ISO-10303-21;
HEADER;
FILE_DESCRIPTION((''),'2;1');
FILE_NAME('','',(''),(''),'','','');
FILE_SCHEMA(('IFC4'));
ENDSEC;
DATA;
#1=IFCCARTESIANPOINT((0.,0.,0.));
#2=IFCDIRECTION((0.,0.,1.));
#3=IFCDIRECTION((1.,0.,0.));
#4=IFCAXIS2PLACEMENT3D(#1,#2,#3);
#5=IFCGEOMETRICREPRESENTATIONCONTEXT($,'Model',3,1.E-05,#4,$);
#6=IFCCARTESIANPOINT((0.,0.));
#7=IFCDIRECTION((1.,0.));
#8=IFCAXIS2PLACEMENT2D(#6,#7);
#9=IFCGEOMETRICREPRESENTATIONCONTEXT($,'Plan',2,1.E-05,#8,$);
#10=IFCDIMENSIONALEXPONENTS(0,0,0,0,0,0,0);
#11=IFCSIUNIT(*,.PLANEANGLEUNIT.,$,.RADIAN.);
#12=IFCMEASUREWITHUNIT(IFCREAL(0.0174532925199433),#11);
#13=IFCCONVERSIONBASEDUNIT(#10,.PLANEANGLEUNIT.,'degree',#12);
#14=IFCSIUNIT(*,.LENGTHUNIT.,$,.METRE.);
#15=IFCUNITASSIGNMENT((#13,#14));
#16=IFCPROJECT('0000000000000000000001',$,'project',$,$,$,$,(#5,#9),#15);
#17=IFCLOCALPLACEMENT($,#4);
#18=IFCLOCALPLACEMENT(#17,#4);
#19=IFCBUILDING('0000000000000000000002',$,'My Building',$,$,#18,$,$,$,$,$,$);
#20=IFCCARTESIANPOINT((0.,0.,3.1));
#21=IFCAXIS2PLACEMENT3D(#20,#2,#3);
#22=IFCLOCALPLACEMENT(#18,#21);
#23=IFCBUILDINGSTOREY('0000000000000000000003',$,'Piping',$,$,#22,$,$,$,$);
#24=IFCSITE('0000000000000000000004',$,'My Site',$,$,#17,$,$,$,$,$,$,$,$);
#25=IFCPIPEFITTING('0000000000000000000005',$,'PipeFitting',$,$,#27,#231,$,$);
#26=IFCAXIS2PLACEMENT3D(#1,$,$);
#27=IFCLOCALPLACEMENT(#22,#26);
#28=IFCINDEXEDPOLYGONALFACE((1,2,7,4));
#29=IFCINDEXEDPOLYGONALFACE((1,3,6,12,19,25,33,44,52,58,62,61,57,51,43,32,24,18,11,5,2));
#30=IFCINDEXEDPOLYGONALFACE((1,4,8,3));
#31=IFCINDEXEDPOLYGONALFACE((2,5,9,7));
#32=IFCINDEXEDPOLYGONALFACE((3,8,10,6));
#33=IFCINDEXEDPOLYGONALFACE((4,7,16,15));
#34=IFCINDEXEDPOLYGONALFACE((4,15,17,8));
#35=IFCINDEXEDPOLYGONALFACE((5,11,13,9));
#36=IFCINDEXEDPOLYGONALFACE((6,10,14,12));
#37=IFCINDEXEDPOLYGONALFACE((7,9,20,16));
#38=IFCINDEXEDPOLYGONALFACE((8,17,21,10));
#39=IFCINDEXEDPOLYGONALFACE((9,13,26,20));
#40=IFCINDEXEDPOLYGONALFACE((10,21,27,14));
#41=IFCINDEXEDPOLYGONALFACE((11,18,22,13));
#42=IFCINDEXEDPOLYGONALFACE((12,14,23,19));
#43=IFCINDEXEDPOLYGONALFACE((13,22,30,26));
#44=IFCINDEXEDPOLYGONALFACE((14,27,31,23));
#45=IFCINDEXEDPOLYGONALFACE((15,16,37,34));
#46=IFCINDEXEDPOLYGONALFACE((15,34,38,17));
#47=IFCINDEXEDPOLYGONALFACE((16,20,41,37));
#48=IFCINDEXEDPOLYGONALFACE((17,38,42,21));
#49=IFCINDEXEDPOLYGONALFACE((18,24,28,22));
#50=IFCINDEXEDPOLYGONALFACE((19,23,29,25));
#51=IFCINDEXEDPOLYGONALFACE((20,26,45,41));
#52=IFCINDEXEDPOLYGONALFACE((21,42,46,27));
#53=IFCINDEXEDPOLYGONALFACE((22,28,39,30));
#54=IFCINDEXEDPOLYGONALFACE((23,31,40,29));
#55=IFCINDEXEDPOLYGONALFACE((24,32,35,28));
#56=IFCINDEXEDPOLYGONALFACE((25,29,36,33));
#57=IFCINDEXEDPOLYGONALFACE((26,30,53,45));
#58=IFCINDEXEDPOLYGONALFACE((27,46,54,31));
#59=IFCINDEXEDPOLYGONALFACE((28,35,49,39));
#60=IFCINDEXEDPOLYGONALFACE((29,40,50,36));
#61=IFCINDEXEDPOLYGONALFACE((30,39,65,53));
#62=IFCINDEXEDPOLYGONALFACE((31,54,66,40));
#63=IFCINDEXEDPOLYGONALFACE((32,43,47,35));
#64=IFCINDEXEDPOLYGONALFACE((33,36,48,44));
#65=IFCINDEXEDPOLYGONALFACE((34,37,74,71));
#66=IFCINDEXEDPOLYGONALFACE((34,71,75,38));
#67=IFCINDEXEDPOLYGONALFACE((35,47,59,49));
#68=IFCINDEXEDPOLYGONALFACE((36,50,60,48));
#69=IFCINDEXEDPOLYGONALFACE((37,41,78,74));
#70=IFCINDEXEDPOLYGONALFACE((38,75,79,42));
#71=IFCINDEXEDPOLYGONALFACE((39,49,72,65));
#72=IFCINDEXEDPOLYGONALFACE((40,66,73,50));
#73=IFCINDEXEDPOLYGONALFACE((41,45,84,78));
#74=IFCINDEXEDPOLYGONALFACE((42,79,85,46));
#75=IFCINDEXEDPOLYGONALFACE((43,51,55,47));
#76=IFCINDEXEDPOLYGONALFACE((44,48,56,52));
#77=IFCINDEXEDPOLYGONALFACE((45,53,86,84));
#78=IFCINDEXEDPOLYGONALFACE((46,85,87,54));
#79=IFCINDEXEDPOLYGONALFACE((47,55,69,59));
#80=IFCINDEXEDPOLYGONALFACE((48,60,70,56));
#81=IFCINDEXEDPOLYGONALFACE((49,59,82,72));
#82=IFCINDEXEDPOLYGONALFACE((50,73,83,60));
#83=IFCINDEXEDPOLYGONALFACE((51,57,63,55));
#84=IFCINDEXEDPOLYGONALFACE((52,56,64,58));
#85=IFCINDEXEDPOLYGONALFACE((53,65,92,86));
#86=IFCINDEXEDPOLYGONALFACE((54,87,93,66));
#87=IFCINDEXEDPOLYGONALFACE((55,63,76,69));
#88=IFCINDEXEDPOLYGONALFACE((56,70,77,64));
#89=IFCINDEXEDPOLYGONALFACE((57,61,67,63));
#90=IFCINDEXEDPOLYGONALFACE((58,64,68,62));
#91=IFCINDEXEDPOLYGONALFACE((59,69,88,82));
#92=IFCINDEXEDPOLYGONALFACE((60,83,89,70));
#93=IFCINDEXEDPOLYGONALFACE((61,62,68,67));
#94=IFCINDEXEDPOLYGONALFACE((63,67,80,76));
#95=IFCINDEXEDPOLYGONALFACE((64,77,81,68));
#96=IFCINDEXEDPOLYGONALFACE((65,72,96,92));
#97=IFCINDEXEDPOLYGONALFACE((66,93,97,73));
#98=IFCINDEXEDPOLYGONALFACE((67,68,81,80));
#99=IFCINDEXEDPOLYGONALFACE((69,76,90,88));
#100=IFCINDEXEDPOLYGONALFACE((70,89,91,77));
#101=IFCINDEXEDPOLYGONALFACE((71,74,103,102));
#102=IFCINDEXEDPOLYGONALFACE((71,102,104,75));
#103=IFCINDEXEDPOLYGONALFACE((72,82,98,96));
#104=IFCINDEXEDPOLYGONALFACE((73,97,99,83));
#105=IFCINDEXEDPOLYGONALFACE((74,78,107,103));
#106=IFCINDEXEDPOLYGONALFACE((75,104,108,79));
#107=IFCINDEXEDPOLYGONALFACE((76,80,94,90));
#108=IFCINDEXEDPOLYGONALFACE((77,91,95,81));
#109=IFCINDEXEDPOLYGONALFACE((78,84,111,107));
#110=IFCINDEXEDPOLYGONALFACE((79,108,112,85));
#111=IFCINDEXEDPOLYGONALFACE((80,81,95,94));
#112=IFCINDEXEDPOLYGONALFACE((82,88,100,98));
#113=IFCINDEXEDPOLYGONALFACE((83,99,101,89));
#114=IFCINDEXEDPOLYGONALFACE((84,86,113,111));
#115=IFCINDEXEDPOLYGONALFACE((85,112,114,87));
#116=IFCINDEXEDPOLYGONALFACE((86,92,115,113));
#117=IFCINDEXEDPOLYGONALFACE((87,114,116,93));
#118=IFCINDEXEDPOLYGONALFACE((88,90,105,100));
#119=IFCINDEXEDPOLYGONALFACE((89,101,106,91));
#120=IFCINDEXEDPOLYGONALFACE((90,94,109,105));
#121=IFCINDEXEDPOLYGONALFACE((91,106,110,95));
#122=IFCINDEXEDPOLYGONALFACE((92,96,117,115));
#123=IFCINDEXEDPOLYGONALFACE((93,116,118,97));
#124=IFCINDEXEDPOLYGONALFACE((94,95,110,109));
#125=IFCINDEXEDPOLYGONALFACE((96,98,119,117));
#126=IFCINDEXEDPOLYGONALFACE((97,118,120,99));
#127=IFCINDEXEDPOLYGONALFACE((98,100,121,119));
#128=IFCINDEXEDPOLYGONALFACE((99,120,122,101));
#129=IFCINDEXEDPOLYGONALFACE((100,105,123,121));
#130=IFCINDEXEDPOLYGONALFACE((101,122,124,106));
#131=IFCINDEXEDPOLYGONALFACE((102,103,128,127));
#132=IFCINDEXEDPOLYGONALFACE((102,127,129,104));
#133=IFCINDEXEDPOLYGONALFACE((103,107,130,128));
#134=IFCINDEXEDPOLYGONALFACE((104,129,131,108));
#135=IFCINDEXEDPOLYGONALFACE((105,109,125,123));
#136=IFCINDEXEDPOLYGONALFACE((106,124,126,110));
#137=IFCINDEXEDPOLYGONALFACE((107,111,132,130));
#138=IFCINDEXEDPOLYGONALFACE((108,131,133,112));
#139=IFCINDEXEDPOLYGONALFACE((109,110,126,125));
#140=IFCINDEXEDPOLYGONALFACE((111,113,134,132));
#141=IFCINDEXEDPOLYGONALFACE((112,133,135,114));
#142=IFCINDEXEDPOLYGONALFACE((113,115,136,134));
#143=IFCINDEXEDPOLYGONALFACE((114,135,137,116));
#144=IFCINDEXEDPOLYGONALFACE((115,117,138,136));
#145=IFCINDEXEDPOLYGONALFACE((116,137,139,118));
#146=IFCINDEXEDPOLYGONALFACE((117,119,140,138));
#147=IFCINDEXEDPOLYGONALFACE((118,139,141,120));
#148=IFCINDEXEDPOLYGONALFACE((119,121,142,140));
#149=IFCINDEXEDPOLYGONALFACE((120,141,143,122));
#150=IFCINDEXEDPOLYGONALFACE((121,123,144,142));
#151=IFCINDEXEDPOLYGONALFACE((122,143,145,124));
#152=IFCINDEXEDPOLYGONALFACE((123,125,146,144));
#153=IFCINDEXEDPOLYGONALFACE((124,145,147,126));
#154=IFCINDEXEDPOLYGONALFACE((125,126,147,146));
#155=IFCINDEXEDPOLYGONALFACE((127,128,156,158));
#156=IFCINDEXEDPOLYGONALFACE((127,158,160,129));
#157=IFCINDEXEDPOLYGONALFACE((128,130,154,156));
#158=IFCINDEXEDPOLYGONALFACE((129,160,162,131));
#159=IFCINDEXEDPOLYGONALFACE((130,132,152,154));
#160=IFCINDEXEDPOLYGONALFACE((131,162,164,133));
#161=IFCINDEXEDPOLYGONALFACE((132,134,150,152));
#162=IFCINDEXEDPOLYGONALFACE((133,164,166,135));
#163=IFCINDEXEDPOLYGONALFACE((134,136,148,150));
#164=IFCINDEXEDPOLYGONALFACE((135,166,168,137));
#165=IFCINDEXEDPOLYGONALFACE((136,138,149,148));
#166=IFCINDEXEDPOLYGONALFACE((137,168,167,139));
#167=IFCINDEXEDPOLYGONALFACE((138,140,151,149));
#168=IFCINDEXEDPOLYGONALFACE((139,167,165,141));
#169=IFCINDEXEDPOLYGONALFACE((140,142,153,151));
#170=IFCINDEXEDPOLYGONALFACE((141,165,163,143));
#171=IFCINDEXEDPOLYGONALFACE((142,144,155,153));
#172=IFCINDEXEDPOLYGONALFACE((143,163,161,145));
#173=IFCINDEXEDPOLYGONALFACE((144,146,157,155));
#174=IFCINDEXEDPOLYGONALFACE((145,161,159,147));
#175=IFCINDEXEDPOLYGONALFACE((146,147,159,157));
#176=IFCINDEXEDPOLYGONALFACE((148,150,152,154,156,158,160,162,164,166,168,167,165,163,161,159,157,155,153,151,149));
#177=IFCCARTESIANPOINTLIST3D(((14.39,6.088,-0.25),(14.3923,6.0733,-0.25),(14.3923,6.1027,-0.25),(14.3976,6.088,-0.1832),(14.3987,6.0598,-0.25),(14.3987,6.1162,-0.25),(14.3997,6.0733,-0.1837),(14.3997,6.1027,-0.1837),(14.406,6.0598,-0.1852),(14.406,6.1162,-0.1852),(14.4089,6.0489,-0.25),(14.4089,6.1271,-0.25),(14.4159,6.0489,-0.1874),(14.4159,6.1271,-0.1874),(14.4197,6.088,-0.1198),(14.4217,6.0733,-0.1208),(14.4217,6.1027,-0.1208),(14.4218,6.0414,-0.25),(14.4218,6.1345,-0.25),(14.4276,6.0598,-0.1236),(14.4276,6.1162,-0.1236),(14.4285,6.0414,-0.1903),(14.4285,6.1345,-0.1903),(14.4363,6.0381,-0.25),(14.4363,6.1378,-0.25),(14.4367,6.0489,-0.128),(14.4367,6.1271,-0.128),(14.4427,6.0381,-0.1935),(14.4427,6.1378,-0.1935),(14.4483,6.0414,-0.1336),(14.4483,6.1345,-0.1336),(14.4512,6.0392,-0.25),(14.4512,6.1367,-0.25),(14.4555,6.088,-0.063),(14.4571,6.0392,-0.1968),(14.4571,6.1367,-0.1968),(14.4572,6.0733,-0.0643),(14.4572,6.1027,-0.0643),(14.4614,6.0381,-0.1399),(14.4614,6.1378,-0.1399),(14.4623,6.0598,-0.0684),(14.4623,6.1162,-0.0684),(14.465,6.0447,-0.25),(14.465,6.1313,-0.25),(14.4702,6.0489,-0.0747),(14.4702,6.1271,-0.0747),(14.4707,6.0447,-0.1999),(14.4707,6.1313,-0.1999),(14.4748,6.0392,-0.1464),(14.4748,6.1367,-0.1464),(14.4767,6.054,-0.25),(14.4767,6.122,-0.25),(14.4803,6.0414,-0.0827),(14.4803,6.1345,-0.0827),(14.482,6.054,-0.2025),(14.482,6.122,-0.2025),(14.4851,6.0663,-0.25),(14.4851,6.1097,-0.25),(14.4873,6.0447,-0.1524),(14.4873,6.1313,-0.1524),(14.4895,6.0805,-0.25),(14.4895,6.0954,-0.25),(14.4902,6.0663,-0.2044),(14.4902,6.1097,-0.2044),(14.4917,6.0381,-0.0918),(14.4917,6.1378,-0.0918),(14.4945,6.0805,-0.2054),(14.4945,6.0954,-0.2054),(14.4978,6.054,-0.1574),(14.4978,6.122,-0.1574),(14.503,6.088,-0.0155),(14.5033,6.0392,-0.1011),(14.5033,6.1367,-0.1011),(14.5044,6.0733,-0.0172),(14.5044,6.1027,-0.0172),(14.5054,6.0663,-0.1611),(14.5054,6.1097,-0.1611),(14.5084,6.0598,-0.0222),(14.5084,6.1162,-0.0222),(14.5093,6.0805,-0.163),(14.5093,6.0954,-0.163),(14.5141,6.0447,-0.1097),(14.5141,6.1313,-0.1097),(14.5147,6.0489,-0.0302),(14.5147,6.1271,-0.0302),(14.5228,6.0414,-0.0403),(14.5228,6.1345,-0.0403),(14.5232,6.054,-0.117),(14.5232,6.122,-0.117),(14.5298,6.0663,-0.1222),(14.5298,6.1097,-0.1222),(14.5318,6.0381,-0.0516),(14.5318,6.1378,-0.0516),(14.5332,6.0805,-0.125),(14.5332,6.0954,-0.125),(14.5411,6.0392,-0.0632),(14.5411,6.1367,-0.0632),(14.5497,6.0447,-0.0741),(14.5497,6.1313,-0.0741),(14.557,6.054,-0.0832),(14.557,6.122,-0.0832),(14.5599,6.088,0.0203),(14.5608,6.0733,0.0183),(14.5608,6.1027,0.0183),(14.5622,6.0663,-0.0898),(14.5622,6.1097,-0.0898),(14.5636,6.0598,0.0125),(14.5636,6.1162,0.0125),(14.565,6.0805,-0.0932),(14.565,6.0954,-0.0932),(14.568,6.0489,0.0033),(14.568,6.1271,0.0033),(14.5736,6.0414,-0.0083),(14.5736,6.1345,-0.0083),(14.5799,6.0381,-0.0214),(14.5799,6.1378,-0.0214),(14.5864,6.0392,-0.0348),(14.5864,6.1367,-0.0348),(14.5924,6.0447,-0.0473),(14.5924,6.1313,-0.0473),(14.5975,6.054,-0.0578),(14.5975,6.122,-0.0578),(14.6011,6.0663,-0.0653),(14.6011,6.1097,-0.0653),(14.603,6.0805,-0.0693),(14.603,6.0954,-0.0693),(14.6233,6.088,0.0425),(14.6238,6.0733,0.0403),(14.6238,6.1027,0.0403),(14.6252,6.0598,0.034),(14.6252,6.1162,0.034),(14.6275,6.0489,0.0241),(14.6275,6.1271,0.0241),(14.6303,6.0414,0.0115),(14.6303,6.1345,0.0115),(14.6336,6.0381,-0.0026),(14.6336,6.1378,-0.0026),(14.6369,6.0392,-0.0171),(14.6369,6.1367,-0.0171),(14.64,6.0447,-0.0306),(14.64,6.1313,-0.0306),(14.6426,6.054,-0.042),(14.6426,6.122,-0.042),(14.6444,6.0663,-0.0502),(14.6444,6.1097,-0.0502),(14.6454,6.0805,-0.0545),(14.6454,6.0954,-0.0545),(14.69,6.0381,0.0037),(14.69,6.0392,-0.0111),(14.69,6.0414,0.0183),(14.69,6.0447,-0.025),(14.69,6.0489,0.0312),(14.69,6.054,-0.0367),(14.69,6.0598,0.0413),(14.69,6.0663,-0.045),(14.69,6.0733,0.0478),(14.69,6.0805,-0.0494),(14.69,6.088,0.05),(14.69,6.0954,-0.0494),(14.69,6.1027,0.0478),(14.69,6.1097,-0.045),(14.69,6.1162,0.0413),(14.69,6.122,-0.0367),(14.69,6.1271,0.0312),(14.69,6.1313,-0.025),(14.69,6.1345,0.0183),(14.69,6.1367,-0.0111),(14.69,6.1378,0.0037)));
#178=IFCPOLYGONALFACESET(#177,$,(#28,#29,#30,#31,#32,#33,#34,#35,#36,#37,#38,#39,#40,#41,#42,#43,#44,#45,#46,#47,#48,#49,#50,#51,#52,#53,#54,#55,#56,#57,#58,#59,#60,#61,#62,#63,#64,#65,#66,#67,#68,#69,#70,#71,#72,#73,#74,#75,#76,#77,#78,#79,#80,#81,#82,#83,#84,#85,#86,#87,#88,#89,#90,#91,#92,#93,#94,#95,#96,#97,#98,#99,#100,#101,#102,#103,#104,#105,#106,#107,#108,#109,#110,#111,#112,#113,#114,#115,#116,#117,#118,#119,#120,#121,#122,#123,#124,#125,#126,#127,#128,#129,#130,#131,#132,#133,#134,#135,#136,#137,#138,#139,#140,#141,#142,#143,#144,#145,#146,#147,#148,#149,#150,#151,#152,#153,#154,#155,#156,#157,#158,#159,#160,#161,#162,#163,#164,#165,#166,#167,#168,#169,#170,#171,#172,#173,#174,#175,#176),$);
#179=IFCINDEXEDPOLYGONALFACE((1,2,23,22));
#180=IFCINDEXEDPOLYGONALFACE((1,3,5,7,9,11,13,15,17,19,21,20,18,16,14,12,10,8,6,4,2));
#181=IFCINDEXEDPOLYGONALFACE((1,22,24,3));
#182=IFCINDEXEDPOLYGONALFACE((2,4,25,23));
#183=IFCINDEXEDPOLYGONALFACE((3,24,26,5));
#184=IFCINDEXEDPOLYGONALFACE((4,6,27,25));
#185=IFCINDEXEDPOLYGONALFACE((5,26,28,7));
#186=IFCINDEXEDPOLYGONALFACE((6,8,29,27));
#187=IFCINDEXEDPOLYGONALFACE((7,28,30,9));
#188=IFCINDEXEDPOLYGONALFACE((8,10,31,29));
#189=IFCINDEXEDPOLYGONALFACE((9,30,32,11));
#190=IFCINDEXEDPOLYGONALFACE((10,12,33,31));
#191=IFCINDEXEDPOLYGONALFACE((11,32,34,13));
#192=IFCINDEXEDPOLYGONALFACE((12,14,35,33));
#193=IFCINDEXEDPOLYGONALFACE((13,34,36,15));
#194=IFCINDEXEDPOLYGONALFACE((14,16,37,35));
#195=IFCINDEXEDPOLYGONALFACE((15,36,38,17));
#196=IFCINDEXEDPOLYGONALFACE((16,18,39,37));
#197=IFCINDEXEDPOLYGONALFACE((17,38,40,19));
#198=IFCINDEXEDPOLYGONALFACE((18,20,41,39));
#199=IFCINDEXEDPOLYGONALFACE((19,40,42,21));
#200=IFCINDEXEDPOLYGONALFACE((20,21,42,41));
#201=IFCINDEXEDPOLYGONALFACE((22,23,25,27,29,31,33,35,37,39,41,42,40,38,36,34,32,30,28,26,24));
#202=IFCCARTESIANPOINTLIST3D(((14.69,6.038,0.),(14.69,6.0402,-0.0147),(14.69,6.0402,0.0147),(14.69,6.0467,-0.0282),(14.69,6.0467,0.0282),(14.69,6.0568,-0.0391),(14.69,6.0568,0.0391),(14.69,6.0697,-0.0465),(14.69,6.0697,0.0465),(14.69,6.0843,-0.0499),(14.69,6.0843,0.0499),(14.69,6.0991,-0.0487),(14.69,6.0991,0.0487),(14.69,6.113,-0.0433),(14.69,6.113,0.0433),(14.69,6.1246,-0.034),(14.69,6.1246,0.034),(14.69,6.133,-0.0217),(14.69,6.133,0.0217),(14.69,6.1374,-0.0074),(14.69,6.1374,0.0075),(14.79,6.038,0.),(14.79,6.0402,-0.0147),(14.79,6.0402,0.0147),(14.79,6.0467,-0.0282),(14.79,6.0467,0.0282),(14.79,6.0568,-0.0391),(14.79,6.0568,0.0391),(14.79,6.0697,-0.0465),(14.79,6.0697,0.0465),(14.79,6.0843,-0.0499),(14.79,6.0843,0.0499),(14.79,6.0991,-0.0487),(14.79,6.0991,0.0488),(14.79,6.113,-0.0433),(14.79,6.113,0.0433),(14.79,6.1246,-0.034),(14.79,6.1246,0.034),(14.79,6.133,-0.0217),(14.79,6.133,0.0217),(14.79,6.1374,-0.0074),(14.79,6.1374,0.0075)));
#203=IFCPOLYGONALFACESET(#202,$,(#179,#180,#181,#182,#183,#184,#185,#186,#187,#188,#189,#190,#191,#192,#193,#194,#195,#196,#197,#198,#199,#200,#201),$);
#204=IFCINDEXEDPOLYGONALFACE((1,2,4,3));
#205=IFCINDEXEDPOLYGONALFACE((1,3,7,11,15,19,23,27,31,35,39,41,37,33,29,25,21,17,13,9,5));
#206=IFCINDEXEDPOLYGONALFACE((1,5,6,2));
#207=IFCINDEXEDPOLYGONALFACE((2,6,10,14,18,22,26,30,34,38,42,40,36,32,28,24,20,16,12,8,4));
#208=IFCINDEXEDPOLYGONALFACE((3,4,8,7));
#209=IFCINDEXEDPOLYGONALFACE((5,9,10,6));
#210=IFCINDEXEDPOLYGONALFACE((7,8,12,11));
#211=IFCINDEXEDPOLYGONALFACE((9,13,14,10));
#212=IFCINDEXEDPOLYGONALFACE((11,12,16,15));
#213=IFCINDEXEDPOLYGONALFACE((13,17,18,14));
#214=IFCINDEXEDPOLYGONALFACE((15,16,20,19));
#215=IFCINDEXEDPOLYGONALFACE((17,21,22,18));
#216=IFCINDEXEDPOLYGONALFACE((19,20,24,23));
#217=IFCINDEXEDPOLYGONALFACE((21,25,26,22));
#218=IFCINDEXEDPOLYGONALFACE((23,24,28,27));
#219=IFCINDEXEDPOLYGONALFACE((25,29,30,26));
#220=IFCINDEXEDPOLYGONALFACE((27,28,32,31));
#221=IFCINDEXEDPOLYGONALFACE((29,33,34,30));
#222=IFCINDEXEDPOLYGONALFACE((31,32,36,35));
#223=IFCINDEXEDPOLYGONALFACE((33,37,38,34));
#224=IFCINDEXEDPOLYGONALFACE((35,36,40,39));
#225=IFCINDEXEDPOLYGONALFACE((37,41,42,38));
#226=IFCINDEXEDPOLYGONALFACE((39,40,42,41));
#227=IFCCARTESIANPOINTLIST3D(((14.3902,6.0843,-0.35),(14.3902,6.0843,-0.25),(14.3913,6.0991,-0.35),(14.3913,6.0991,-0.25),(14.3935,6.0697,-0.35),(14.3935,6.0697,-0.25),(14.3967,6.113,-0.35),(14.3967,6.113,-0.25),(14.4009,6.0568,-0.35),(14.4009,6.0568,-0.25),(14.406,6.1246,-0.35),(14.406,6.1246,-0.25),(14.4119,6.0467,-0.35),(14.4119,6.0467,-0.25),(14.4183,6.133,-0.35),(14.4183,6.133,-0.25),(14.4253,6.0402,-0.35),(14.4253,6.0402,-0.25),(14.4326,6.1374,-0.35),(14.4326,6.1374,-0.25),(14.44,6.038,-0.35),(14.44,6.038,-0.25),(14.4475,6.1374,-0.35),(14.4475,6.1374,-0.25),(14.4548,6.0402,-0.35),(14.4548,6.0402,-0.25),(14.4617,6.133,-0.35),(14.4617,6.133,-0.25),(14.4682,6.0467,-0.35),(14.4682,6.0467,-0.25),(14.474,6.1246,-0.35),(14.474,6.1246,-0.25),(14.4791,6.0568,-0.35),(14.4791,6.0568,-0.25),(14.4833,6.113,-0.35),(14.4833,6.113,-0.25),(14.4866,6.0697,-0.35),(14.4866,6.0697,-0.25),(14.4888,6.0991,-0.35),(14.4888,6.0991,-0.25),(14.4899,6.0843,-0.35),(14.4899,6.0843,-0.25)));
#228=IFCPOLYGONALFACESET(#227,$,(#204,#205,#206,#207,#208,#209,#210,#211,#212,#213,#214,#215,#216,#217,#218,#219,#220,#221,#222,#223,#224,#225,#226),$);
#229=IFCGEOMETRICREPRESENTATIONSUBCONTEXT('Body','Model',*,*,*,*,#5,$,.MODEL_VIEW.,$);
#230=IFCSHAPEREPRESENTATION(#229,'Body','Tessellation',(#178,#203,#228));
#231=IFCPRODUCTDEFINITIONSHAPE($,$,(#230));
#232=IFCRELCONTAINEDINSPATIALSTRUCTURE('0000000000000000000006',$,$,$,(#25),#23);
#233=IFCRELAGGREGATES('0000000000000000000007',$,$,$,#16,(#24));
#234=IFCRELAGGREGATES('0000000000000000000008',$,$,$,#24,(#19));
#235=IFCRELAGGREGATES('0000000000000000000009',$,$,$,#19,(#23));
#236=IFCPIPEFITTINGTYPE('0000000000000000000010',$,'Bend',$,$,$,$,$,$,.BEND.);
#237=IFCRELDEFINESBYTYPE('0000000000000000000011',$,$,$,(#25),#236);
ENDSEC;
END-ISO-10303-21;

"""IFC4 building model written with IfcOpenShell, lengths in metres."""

from ifc_helpers import new_model, entity, si_unit, converted_unit, frame, origin_with_axes, origin_2d_with_axis, place, context, subcontext, project, spatial, circle, extrude, source, transform, mapped, type_object, type_shapes, element, save


model = new_model("IFC4")

# Units and contexts
model_context = context("Model", 3, precision=1e-05, world=origin_with_axes())
plan_context = context("Plan", 2, precision=1e-05, world=origin_2d_with_axis())
body_context = subcontext(model_context, "Body", "Model", "MODEL_VIEW")
ifc_project = project(units=[converted_unit("PLANEANGLEUNIT", "degree", entity("IfcReal", 0.0174532925199433), si_unit("PLANEANGLEUNIT", "RADIAN"), dimensions=[0, 0, 0, 0, 0, 0, 0]), si_unit("LENGTHUNIT", "METRE")], contexts=[model_context, plan_context])

# Site, building, storey
site_placement = place(None, origin_with_axes())
site = spatial("IfcSite", under=ifc_project, at=site_placement, Name="My Site")
building_placement = place(site_placement, origin_with_axes())
building = spatial("IfcBuilding", under=site, at=building_placement, Name="My Building")
storey_placement = place(building_placement, frame((0.0, 0.0, 3.1), z_axis=(0.0, 0.0, 1.0), x_axis=(1.0, 0.0, 0.0)))
storey = spatial("IfcBuildingStorey", under=building, at=storey_placement, Name="Piping")

# Pipe fitting
pipe_fitting_type_1 = type_object("IfcPipeFittingType", Name="Bend", PredefinedType="BEND")
shared_shape_1 = source(origin_with_axes(), body_context, "Body", "SolidModel", [
    entity("IfcSweptDiskSolid", entity("IfcIndexedPolyCurve", entity("IfcCartesianPointList3D", [[0.0, 0.0, 0.1], [0.0, -0.0732, 0.2768], [0.0, -0.25, 0.35]]), [entity("IfcArcIndex", [1, 2, 3])]), 0.05),
    extrude(circle(Radius=0.05), origin_with_axes(), (0.0, 0.0, 1.0), 0.1),
    extrude(circle(Radius=0.05), frame((0.0, -0.25, 0.35), z_axis=(0.0, -1.0, 0.000022), x_axis=(1.0, 0.0, 0.0)), (0.0, 0.0, 1.0), 0.1),
])
type_shapes(pipe_fitting_type_1, [shared_shape_1])
for number, where, z_axis, x_axis, name in (
    (1, (14.79, 6.088, 0.0), (-1.0, 0.0, -0.000022), (0.0, -1.0, 0.0), "PipeFitting"),
):
    element("IfcPipeFitting", number, at=place(storey_placement, frame(where, z_axis=z_axis, x_axis=x_axis)), inside=storey, type_object=pipe_fitting_type_1, Name=name, context=body_context, shape_type="MappedRepresentation", body=[
        mapped(shared_shape_1, transform((0.0, 0.0, 0.0), x_axis=(1.0, 0.0, 0.0), y_axis=(0.0, 1.0, 0.0), z_axis=(0.0, 0.0, 1.0), scale=1.0)),
    ])

save(model, "model.ifc")
